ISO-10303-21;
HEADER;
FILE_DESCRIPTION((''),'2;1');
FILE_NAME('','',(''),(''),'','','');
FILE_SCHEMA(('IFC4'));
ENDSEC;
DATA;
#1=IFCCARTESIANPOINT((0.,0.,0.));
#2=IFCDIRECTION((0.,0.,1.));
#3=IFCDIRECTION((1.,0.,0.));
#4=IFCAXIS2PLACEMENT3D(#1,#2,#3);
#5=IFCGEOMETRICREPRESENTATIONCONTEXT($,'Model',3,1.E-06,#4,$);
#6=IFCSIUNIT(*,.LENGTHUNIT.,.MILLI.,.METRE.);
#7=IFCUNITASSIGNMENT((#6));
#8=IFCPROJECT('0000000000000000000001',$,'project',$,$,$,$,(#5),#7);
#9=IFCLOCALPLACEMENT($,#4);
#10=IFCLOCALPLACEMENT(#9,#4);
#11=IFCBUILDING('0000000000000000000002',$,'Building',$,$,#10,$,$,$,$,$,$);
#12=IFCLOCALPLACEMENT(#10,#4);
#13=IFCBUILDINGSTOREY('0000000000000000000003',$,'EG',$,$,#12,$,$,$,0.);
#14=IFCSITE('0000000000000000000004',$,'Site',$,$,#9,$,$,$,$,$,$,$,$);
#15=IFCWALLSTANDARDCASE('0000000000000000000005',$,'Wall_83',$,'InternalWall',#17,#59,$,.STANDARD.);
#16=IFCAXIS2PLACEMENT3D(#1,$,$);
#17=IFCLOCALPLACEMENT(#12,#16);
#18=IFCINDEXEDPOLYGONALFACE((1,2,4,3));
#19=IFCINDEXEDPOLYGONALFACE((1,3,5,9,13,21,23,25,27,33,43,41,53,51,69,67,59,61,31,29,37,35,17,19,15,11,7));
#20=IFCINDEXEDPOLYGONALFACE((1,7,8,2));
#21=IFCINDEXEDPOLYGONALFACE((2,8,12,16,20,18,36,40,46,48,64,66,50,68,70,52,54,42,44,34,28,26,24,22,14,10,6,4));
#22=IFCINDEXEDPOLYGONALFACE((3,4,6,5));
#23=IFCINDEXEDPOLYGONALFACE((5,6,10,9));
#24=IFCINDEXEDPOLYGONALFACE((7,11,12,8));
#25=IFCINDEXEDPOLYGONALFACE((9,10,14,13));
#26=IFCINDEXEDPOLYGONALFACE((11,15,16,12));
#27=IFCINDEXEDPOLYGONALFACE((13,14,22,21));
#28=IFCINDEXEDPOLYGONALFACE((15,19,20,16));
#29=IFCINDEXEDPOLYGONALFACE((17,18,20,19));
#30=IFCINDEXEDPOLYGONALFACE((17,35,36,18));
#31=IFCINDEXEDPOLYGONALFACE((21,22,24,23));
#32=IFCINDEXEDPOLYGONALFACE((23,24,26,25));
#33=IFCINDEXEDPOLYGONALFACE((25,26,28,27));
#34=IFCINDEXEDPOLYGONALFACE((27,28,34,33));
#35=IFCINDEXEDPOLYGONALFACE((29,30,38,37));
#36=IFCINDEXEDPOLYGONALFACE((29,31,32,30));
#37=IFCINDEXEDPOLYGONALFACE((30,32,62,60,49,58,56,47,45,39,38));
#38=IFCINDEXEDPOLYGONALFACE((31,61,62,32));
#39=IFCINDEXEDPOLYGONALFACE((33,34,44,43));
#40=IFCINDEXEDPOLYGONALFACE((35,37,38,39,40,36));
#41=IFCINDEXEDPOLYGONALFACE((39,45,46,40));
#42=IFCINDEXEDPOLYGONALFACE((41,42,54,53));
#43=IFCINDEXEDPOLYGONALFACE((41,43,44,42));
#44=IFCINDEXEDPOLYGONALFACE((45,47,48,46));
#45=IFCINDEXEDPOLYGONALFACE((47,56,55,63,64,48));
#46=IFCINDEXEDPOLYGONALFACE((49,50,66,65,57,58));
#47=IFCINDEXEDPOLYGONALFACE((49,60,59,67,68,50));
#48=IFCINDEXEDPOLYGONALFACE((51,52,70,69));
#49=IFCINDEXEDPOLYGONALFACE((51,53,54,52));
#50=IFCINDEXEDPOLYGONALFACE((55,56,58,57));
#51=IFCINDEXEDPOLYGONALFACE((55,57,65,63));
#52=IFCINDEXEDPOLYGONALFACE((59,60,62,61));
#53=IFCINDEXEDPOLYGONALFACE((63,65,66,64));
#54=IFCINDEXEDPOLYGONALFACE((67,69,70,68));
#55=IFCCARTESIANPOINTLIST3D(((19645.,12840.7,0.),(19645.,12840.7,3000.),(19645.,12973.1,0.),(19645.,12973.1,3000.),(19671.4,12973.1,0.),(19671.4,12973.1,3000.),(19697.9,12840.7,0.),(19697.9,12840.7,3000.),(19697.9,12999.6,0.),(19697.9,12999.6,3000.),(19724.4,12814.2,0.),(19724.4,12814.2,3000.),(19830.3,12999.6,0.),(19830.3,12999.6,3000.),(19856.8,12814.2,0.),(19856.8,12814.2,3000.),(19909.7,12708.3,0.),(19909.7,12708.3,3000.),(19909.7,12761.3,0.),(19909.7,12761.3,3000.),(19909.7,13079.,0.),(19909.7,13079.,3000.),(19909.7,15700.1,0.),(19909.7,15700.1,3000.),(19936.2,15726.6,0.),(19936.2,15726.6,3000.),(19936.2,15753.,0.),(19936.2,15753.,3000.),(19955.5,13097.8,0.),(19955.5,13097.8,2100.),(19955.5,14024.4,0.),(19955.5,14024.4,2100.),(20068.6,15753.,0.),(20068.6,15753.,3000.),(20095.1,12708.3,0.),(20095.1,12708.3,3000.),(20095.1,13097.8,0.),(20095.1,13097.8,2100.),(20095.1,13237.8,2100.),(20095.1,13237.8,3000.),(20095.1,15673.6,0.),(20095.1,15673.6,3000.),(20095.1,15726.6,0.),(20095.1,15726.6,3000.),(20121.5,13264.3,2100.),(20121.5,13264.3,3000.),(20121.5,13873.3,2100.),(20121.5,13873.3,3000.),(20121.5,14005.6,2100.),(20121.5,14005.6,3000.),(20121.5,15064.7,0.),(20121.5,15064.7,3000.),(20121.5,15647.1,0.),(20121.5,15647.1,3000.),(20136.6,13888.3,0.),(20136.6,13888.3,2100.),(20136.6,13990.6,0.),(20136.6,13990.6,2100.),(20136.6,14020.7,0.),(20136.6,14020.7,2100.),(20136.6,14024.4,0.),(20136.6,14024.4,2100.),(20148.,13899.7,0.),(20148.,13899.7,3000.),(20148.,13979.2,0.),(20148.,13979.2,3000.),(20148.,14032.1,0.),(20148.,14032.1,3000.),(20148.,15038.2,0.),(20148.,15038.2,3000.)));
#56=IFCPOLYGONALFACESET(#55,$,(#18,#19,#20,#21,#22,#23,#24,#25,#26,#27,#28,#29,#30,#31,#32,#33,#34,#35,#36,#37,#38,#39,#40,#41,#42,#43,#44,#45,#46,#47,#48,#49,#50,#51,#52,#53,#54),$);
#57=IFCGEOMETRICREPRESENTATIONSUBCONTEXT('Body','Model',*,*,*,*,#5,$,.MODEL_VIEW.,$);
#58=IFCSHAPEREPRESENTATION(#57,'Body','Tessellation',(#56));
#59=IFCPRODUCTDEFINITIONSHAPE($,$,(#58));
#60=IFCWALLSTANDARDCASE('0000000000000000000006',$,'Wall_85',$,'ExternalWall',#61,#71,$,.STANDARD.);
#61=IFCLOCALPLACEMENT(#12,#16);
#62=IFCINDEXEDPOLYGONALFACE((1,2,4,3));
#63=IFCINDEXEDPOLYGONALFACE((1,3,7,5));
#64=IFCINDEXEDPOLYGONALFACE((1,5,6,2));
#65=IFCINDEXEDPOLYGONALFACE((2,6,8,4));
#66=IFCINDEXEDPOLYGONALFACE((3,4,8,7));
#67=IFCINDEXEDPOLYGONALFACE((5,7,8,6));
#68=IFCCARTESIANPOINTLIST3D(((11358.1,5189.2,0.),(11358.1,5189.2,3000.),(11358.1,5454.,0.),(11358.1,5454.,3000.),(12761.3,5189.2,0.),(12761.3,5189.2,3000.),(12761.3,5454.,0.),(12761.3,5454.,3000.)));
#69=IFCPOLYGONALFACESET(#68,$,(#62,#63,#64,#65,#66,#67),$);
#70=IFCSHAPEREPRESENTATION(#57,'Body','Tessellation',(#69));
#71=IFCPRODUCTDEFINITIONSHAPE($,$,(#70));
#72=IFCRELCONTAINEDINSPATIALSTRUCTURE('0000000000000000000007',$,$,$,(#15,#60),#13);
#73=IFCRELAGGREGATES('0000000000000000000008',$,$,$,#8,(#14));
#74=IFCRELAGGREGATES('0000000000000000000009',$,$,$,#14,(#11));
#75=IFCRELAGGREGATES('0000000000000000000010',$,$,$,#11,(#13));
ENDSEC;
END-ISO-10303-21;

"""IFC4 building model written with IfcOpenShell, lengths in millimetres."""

from ifc_helpers import new_model, si_unit, frame, origin_with_axes, place, context, subcontext, project, spatial, polyline, rectangle, outline, extrude, element, save


model = new_model("IFC4")

# Units and contexts
model_context = context("Model", 3, precision=1e-06, world=origin_with_axes())
body_context = subcontext(model_context, "Body", "Model", "MODEL_VIEW")
ifc_project = project(units=[si_unit("LENGTHUNIT", "METRE", prefix="MILLI")], contexts=[model_context])

# Site, building, storey
site_placement = place(None, origin_with_axes())
site = spatial("IfcSite", under=ifc_project, at=site_placement, Name="Site")
building_placement = place(site_placement, origin_with_axes())
building = spatial("IfcBuilding", under=site, at=building_placement, Name="Building")
storey_placement = place(building_placement, origin_with_axes())
storey = spatial("IfcBuildingStorey", under=building, at=storey_placement, Name="EG", Elevation=0.0)

# Wall, opening
wall_1_placement = place(storey_placement, origin_with_axes())
wall_1 = element("IfcWallStandardCase", 1, at=wall_1_placement, inside=storey, Name="Wall_83", ObjectType="InternalWall", PredefinedType="STANDARD", context=body_context, shape_type="SweptSolid", body=[
    extrude(outline(polyline([(19909.7, 12708.3, 0.0), (19909.7, 12761.3, 0.0), (19856.8, 12814.2, 0.0), (19724.4, 12814.2, 0.0), (19697.9, 12840.7, 0.0), (19645.0, 12840.7, 0.0), (19645.0, 12973.1, 0.0), (19671.4, 12973.1, 0.0), (19697.9, 12999.6, 0.0), (19830.3, 12999.6, 0.0), (19909.7, 13079.0, 0.0), (19909.7, 15700.1, 0.0), (19936.2, 15726.6, 0.0), (19936.2, 15753.0, 0.0), (20068.6, 15753.0, 0.0), (20095.1, 15726.6, 0.0), (20095.1, 15673.6, 0.0), (20121.5, 15647.1, 0.0), (20121.5, 15064.7, 0.0), (20148.0, 15038.2, 0.0), (20148.0, 14032.1, 0.0), (20121.5, 14005.6, 0.0), (20148.0, 13979.2, 0.0), (20148.0, 13899.7, 0.0), (20121.5, 13873.3, 0.0), (20121.5, 13264.3, 0.0), (20095.1, 13237.8, 0.0), (20095.1, 12708.3, 0.0), (19909.7, 12708.3, 0.0)])), origin_with_axes(), (0.0, 0.0, 1.0), 3000.0),
])
opening_1_placement = place(wall_1_placement, origin_with_axes())
element("IfcOpeningElement", 2, at=opening_1_placement, inside=storey, cuts=wall_1, context=body_context, shape_type="SweptSolid", body=[
    extrude(rectangle(XDim=926.6, YDim=181.1), frame((20046.0, 13561.1, 0.0), z_axis=(0.0, 0.0, 1.0), x_axis=(0.0, -1.0, 0.0)), (0.0, 0.0, 1.0), 2100.0),
])

# Wall
for number, where, z_axis, x_axis, name in (
    (3, (0.0, 0.0, 0.0), (0.0, 0.0, 1.0), (1.0, 0.0, 0.0), "Wall_85"),
):
    element("IfcWallStandardCase", number, at=place(storey_placement, frame(where, z_axis=z_axis, x_axis=x_axis)), inside=storey, Name=name, ObjectType="ExternalWall", PredefinedType="STANDARD", context=body_context, shape_type="SweptSolid", body=[
        extrude(outline(polyline([(11358.1, 5189.2, 0.0), (11358.1, 5454.0, 0.0), (12761.3, 5454.0, 0.0), (12761.3, 5189.2, 0.0), (11358.1, 5189.2, 0.0)])), origin_with_axes(), (0.0, 0.0, 1.0), 3000.0),
    ])

save(model, "model.ifc")
